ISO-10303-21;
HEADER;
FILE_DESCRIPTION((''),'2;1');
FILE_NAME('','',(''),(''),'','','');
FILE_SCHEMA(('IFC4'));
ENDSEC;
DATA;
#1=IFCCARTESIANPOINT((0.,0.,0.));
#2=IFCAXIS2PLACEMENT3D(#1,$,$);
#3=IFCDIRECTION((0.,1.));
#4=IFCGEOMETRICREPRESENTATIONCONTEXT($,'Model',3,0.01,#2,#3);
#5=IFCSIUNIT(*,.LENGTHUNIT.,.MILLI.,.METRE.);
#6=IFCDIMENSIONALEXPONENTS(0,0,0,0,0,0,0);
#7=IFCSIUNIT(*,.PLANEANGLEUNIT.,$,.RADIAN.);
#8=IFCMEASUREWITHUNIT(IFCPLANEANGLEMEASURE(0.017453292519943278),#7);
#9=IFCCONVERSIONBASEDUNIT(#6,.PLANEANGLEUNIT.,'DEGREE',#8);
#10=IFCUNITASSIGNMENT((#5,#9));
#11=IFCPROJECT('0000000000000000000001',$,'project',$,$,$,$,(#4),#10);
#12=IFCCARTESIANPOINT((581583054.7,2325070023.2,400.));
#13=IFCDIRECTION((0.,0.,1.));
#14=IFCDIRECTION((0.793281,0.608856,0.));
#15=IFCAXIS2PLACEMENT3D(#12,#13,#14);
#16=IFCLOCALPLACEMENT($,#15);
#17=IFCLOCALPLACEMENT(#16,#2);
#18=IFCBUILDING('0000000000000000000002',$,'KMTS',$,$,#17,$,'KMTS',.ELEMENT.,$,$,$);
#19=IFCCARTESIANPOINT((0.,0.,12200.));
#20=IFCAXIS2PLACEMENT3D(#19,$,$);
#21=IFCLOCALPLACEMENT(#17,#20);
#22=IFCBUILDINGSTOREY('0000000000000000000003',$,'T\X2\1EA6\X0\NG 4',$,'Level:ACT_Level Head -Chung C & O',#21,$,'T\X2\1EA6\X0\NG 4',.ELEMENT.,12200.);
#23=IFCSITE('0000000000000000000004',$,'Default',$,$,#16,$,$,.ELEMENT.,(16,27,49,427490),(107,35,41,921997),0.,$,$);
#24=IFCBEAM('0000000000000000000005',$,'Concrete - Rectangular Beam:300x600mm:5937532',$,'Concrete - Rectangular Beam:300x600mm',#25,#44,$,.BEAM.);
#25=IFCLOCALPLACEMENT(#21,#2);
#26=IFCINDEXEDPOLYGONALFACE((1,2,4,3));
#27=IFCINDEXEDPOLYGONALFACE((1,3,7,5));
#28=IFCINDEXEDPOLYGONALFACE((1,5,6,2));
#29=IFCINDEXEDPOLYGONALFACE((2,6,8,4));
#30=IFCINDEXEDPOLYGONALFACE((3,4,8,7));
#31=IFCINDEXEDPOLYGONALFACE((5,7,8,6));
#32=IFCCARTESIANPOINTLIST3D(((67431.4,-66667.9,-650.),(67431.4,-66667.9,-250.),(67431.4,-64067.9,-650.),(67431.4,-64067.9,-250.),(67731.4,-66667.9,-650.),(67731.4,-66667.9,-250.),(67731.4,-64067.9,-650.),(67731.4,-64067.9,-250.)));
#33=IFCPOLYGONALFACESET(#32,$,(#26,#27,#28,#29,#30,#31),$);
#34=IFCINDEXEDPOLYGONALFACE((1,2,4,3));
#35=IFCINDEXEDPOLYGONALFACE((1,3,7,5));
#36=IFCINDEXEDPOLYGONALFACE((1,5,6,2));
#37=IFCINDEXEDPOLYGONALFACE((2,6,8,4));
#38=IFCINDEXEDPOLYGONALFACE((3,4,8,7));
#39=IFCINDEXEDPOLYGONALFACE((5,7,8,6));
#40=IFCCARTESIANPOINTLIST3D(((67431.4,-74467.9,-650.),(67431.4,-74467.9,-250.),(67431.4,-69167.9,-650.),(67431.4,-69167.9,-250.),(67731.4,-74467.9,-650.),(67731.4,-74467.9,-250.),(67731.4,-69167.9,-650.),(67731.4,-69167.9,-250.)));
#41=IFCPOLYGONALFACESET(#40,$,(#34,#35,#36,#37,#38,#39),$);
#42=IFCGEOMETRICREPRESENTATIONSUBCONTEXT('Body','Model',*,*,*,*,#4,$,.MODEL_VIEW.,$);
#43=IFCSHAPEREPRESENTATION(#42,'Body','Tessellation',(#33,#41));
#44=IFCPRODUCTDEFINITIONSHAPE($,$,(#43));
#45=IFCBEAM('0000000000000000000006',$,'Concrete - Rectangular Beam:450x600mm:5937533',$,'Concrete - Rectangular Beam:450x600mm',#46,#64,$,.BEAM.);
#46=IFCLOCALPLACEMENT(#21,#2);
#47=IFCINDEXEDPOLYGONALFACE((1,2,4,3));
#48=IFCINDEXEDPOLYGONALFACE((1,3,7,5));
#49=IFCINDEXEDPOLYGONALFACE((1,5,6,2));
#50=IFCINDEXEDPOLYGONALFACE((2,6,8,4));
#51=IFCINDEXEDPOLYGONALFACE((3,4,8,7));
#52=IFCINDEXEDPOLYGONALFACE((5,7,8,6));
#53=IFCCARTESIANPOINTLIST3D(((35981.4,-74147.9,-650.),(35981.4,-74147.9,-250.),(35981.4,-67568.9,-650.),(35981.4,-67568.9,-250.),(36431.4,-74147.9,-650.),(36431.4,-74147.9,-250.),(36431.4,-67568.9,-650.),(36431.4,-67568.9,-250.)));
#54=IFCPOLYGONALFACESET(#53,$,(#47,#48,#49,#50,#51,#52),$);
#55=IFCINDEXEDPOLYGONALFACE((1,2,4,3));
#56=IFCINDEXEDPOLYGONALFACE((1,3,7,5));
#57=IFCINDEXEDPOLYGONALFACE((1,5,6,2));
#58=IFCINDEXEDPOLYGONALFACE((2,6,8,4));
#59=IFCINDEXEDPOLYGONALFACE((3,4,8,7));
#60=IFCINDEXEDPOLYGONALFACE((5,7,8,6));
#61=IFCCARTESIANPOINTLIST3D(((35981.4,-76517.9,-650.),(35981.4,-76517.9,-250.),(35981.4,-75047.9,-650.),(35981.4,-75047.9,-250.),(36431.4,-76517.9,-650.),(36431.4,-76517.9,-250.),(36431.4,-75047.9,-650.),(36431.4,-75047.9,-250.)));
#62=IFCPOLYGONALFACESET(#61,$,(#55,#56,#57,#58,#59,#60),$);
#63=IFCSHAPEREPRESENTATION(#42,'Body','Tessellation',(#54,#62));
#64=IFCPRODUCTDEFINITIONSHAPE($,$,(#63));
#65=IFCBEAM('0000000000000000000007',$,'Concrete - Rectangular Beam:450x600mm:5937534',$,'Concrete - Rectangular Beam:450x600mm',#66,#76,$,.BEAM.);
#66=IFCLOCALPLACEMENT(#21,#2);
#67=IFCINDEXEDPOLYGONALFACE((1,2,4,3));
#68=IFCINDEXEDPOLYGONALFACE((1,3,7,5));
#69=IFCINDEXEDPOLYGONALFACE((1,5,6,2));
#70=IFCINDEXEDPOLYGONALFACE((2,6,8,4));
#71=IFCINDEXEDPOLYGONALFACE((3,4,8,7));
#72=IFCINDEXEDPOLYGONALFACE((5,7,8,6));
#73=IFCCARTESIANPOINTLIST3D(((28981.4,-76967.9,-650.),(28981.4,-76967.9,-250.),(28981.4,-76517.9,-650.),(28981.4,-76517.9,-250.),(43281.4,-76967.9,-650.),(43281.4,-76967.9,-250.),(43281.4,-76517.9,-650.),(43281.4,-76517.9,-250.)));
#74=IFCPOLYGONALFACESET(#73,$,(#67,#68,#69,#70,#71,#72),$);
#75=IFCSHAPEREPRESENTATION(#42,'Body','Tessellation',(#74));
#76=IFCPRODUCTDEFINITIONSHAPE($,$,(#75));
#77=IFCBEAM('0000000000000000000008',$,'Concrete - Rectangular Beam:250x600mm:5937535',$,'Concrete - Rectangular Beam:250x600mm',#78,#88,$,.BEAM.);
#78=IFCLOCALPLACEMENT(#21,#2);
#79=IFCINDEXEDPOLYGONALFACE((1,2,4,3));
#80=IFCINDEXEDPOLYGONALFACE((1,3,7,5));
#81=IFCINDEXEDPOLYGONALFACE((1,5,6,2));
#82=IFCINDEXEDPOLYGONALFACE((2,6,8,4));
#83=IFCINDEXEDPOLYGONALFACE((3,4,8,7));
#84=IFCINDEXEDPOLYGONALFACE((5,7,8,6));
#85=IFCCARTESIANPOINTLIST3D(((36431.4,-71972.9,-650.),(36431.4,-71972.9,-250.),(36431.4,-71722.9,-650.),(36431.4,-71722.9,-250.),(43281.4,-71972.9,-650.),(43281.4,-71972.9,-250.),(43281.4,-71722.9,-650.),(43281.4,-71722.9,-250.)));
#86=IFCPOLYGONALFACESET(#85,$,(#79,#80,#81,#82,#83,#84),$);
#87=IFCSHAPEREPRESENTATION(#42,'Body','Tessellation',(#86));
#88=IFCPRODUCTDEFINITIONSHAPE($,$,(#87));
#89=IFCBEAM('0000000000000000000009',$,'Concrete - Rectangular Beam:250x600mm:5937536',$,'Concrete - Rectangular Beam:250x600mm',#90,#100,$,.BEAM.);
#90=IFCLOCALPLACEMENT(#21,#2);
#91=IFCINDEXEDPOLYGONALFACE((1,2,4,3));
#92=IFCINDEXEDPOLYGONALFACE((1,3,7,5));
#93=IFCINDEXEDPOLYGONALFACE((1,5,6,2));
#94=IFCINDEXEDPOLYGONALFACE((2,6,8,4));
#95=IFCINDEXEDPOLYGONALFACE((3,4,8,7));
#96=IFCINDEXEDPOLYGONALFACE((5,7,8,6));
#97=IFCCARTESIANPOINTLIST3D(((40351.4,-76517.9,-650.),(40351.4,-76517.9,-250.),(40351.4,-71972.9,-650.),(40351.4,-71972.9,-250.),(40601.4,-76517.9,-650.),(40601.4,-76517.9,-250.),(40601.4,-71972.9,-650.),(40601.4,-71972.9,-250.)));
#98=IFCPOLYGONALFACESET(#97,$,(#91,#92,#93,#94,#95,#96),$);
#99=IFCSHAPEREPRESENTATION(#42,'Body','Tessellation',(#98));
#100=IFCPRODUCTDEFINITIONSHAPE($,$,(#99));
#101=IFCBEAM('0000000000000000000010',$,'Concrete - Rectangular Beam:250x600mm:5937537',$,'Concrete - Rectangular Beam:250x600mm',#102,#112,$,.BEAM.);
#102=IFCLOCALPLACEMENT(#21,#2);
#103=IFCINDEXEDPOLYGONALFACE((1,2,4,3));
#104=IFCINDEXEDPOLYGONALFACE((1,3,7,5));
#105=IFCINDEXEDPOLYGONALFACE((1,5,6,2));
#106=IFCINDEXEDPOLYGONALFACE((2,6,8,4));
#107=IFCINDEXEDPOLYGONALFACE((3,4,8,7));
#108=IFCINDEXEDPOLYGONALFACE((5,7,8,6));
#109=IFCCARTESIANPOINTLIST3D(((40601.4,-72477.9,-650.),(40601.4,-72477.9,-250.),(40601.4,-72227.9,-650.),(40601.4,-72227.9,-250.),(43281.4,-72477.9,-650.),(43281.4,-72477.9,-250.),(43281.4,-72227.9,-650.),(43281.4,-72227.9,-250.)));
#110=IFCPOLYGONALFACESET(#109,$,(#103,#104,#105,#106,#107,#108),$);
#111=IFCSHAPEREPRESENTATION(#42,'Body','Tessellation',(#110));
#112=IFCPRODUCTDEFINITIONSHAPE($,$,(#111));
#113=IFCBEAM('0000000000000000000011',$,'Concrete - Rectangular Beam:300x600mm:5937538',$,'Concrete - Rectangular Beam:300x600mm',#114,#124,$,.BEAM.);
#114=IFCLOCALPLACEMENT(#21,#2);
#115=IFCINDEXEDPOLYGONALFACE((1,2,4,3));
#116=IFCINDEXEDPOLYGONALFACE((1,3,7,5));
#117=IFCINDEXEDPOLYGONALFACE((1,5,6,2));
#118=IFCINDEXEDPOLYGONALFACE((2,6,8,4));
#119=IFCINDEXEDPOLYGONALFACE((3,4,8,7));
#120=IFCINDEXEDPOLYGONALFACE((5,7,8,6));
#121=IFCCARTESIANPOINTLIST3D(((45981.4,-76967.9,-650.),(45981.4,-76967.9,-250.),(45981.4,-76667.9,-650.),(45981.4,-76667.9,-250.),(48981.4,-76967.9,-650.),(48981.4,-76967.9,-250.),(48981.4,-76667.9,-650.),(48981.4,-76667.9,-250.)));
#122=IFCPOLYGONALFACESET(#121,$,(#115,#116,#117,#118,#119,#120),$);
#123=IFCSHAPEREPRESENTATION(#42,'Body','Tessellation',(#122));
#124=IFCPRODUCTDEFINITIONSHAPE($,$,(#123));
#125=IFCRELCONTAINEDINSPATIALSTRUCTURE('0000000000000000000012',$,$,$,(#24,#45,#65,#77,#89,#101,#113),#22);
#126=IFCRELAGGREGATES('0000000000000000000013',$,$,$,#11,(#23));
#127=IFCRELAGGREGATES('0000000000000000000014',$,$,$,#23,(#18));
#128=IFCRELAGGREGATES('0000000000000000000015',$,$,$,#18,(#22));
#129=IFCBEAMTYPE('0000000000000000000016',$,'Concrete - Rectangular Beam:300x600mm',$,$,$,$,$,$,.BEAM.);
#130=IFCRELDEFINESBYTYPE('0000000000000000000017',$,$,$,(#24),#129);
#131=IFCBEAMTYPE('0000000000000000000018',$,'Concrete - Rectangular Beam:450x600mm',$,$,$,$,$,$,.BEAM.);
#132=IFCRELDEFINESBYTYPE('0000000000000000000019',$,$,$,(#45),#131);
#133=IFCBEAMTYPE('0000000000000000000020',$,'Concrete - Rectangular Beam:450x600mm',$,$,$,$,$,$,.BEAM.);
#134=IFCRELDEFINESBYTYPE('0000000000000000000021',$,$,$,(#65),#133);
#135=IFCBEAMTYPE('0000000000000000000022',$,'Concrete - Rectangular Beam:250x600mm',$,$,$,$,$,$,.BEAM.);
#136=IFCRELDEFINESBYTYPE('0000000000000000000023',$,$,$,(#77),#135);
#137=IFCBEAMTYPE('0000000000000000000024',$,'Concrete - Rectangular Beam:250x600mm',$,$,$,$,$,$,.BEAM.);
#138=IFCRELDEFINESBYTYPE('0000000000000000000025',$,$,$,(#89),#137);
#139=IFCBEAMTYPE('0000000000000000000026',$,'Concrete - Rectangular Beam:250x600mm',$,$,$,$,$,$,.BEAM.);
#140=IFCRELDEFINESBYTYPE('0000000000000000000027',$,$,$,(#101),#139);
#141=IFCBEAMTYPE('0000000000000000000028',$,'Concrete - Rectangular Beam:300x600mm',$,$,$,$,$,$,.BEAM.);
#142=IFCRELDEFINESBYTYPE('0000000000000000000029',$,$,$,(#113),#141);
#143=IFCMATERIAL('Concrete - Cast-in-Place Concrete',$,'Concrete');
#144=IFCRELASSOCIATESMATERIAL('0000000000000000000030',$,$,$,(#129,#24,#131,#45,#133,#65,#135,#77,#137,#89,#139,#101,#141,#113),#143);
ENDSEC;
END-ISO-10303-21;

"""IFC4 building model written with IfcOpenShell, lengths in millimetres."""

from ifc_helpers import new_model, entity, si_unit, converted_unit, direction, frame, origin, place, context, subcontext, project, spatial, indexed_curve, outline, extrude, source, transform, mapped, material, type_object, type_shapes, element, save


model = new_model("IFC4")

# Units and contexts
model_context = context("Model", 3, precision=0.01, world=origin(), true_north=direction((0.0, 1.0)))
body_context = subcontext(model_context, "Body", "Model", "MODEL_VIEW")
ifc_project = project(units=[si_unit("LENGTHUNIT", "METRE", prefix="MILLI"), converted_unit("PLANEANGLEUNIT", "DEGREE", entity("IfcPlaneAngleMeasure", 0.017453292519943278), si_unit("PLANEANGLEUNIT", "RADIAN"), dimensions=[0, 0, 0, 0, 0, 0, 0])], contexts=[model_context])

# Site, building, storey
site_placement = place(None, frame((581583054.7, 2325070023.2, 400.0), z_axis=(0.0, 0.0, 1.0), x_axis=(0.793281, 0.608856, 0.0)))
site = spatial("IfcSite", under=ifc_project, at=site_placement, Name="Default", CompositionType="ELEMENT", RefLatitude=(16, 27, 49, 427490), RefLongitude=(107, 35, 41, 921997), RefElevation=0.0)
building_placement = place(site_placement, origin())
building = spatial("IfcBuilding", under=site, at=building_placement, Name="KMTS", LongName="KMTS", CompositionType="ELEMENT")
storey_placement = place(building_placement, frame((0.0, 0.0, 12200.0)))
storey = spatial("IfcBuildingStorey", under=building, at=storey_placement, Name="TẦNG 4", ObjectType="Level:ACT_Level Head -Chung C & O", LongName="TẦNG 4", CompositionType="ELEMENT", Elevation=12200.0)

# Beams
ifc_material_1 = material(Name="Concrete - Cast-in-Place Concrete", Category="Concrete")
beam_type_1 = type_object("IfcBeamType", Name="Concrete - Rectangular Beam:300x600mm", PredefinedType="BEAM", material=ifc_material_1)
shared_shape_1 = source(origin(), body_context, "Body", "SweptSolid", [
    extrude(outline(indexed_curve([(-150.0, -200.0), (150.0, -200.0), (150.0, 200.0), (-150.0, 200.0), (-150.0, -200.0)], self_intersect=False)), frame((67581.4, -66667.9, 11750.0), z_axis=(0.0, 1.0, 0.0), x_axis=(-1.0, 0.0, 0.0)), (0.0, 0.0, 1.0), 2600.0),
    extrude(outline(indexed_curve([(-150.0, -200.0), (150.0, -200.0), (150.0, 200.0), (-150.0, 200.0), (-150.0, -200.0)], self_intersect=False)), frame((67581.4, -74467.9, 11750.0), z_axis=(0.0, 1.0, 0.0), x_axis=(-1.0, 0.0, 0.0)), (0.0, 0.0, 1.0), 5300.0),
])
type_shapes(beam_type_1, [shared_shape_1])
beam_1_placement = place(storey_placement, frame((0.0, 0.0, -12200.0)))
element("IfcBeam", 1, at=beam_1_placement, inside=storey, type_object=beam_type_1, material=ifc_material_1, Name="Concrete - Rectangular Beam:300x600mm:5937532", ObjectType="Concrete - Rectangular Beam:300x600mm", PredefinedType="BEAM", context=body_context, shape_type="MappedRepresentation", body=[
    mapped(shared_shape_1, transform((0.0, 0.0, 0.0), scale=1.0)),
])
beam_type_2 = type_object("IfcBeamType", Name="Concrete - Rectangular Beam:450x600mm", PredefinedType="BEAM", material=ifc_material_1)
shared_shape_2 = source(origin(), body_context, "Body", "SweptSolid", [
    extrude(outline(indexed_curve([(-225.0, -200.0), (225.0, -200.0), (225.0, 200.0), (-225.0, 200.0), (-225.0, -200.0)], self_intersect=False)), frame((36206.4, -74147.9, 11750.0), z_axis=(0.0, 1.0, 0.0), x_axis=(-1.0, 0.0, 0.0)), (0.0, 0.0, 1.0), 6579.0),
    extrude(outline(indexed_curve([(-225.0, -200.0), (225.0, -200.0), (225.0, 200.0), (-225.0, 200.0), (-225.0, -200.0)], self_intersect=False)), frame((36206.4, -76517.9, 11750.0), z_axis=(0.0, 1.0, 0.0), x_axis=(-1.0, 0.0, 0.0)), (0.0, 0.0, 1.0), 1470.0),
])
type_shapes(beam_type_2, [shared_shape_2])
beam_2_placement = place(storey_placement, frame((0.0, 0.0, -12200.0)))
element("IfcBeam", 2, at=beam_2_placement, inside=storey, type_object=beam_type_2, material=ifc_material_1, Name="Concrete - Rectangular Beam:450x600mm:5937533", ObjectType="Concrete - Rectangular Beam:450x600mm", PredefinedType="BEAM", context=body_context, shape_type="MappedRepresentation", body=[
    mapped(shared_shape_2, transform((0.0, 0.0, 0.0), scale=1.0)),
])
beam_type_3 = type_object("IfcBeamType", Name="Concrete - Rectangular Beam:450x600mm", PredefinedType="BEAM", material=ifc_material_1)
shared_shape_3 = source(origin(), body_context, "Body", "SweptSolid", [
    extrude(outline(indexed_curve([(-200.0, -225.0), (200.0, -225.0), (200.0, 225.0), (-200.0, 225.0), (-200.0, -225.0)], self_intersect=False)), frame((28981.4, -76742.9, 11750.0), z_axis=(1.0, 0.0, 0.0), x_axis=(0.0, 0.0, -1.0)), (0.0, 0.0, 1.0), 14300.0),
])
type_shapes(beam_type_3, [shared_shape_3])
beam_3_placement = place(storey_placement, frame((0.0, 0.0, -12200.0)))
element("IfcBeam", 3, at=beam_3_placement, inside=storey, type_object=beam_type_3, material=ifc_material_1, Name="Concrete - Rectangular Beam:450x600mm:5937534", ObjectType="Concrete - Rectangular Beam:450x600mm", PredefinedType="BEAM", context=body_context, shape_type="MappedRepresentation", body=[
    mapped(shared_shape_3, transform((0.0, 0.0, 0.0), scale=1.0)),
])
beam_type_4 = type_object("IfcBeamType", Name="Concrete - Rectangular Beam:250x600mm", PredefinedType="BEAM", material=ifc_material_1)
shared_shape_4 = source(origin(), body_context, "Body", "SweptSolid", [
    extrude(outline(indexed_curve([(-200.0, -125.0), (200.0, -125.0), (200.0, 125.0), (-200.0, 125.0), (-200.0, -125.0)], self_intersect=False)), frame((36431.4, -71847.9, 11750.0), z_axis=(1.0, 0.0, 0.0), x_axis=(0.0, 0.0, -1.0)), (0.0, 0.0, 1.0), 6850.0),
])
type_shapes(beam_type_4, [shared_shape_4])
beam_4_placement = place(storey_placement, frame((0.0, 0.0, -12200.0)))
element("IfcBeam", 4, at=beam_4_placement, inside=storey, type_object=beam_type_4, material=ifc_material_1, Name="Concrete - Rectangular Beam:250x600mm:5937535", ObjectType="Concrete - Rectangular Beam:250x600mm", PredefinedType="BEAM", context=body_context, shape_type="MappedRepresentation", body=[
    mapped(shared_shape_4, transform((0.0, 0.0, 0.0), scale=1.0)),
])
beam_type_5 = type_object("IfcBeamType", Name="Concrete - Rectangular Beam:250x600mm", PredefinedType="BEAM", material=ifc_material_1)
shared_shape_5 = source(origin(), body_context, "Body", "SweptSolid", [
    extrude(outline(indexed_curve([(-125.0, -200.0), (125.0, -200.0), (125.0, 200.0), (-125.0, 200.0), (-125.0, -200.0)], self_intersect=False)), frame((40476.4, -76517.9, 11750.0), z_axis=(0.0, 1.0, 0.0), x_axis=(-1.0, 0.0, 0.0)), (0.0, 0.0, 1.0), 4545.0),
])
type_shapes(beam_type_5, [shared_shape_5])
beam_5_placement = place(storey_placement, frame((0.0, 0.0, -12200.0)))
element("IfcBeam", 5, at=beam_5_placement, inside=storey, type_object=beam_type_5, material=ifc_material_1, Name="Concrete - Rectangular Beam:250x600mm:5937536", ObjectType="Concrete - Rectangular Beam:250x600mm", PredefinedType="BEAM", context=body_context, shape_type="MappedRepresentation", body=[
    mapped(shared_shape_5, transform((0.0, 0.0, 0.0), scale=1.0)),
])
beam_type_6 = type_object("IfcBeamType", Name="Concrete - Rectangular Beam:250x600mm", PredefinedType="BEAM", material=ifc_material_1)
shared_shape_6 = source(origin(), body_context, "Body", "SweptSolid", [
    extrude(outline(indexed_curve([(-200.0, -125.0), (200.0, -125.0), (200.0, 125.0), (-200.0, 125.0), (-200.0, -125.0)], self_intersect=False)), frame((40601.4, -72352.9, 11750.0), z_axis=(1.0, 0.0, 0.0), x_axis=(0.0, 0.0, -1.0)), (0.0, 0.0, 1.0), 2680.0),
])
type_shapes(beam_type_6, [shared_shape_6])
beam_6_placement = place(storey_placement, frame((0.0, 0.0, -12200.0)))
element("IfcBeam", 6, at=beam_6_placement, inside=storey, type_object=beam_type_6, material=ifc_material_1, Name="Concrete - Rectangular Beam:250x600mm:5937537", ObjectType="Concrete - Rectangular Beam:250x600mm", PredefinedType="BEAM", context=body_context, shape_type="MappedRepresentation", body=[
    mapped(shared_shape_6, transform((0.0, 0.0, 0.0), scale=1.0)),
])
beam_type_7 = type_object("IfcBeamType", Name="Concrete - Rectangular Beam:300x600mm", PredefinedType="BEAM", material=ifc_material_1)
shared_shape_7 = source(origin(), body_context, "Body", "SweptSolid", [
    extrude(outline(indexed_curve([(-200.0, -150.0), (200.0, -150.0), (200.0, 150.0), (-200.0, 150.0), (-200.0, -150.0)], self_intersect=False)), frame((45981.4, -76817.9, 11750.0), z_axis=(1.0, 0.0, 0.0), x_axis=(0.0, 0.0, -1.0)), (0.0, 0.0, 1.0), 3000.0),
])
type_shapes(beam_type_7, [shared_shape_7])
beam_7_placement = place(storey_placement, frame((0.0, 0.0, -12200.0)))
element("IfcBeam", 7, at=beam_7_placement, inside=storey, type_object=beam_type_7, material=ifc_material_1, Name="Concrete - Rectangular Beam:300x600mm:5937538", ObjectType="Concrete - Rectangular Beam:300x600mm", PredefinedType="BEAM", context=body_context, shape_type="MappedRepresentation", body=[
    mapped(shared_shape_7, transform((0.0, 0.0, 0.0), scale=1.0)),
])

save(model, "model.ifc")
